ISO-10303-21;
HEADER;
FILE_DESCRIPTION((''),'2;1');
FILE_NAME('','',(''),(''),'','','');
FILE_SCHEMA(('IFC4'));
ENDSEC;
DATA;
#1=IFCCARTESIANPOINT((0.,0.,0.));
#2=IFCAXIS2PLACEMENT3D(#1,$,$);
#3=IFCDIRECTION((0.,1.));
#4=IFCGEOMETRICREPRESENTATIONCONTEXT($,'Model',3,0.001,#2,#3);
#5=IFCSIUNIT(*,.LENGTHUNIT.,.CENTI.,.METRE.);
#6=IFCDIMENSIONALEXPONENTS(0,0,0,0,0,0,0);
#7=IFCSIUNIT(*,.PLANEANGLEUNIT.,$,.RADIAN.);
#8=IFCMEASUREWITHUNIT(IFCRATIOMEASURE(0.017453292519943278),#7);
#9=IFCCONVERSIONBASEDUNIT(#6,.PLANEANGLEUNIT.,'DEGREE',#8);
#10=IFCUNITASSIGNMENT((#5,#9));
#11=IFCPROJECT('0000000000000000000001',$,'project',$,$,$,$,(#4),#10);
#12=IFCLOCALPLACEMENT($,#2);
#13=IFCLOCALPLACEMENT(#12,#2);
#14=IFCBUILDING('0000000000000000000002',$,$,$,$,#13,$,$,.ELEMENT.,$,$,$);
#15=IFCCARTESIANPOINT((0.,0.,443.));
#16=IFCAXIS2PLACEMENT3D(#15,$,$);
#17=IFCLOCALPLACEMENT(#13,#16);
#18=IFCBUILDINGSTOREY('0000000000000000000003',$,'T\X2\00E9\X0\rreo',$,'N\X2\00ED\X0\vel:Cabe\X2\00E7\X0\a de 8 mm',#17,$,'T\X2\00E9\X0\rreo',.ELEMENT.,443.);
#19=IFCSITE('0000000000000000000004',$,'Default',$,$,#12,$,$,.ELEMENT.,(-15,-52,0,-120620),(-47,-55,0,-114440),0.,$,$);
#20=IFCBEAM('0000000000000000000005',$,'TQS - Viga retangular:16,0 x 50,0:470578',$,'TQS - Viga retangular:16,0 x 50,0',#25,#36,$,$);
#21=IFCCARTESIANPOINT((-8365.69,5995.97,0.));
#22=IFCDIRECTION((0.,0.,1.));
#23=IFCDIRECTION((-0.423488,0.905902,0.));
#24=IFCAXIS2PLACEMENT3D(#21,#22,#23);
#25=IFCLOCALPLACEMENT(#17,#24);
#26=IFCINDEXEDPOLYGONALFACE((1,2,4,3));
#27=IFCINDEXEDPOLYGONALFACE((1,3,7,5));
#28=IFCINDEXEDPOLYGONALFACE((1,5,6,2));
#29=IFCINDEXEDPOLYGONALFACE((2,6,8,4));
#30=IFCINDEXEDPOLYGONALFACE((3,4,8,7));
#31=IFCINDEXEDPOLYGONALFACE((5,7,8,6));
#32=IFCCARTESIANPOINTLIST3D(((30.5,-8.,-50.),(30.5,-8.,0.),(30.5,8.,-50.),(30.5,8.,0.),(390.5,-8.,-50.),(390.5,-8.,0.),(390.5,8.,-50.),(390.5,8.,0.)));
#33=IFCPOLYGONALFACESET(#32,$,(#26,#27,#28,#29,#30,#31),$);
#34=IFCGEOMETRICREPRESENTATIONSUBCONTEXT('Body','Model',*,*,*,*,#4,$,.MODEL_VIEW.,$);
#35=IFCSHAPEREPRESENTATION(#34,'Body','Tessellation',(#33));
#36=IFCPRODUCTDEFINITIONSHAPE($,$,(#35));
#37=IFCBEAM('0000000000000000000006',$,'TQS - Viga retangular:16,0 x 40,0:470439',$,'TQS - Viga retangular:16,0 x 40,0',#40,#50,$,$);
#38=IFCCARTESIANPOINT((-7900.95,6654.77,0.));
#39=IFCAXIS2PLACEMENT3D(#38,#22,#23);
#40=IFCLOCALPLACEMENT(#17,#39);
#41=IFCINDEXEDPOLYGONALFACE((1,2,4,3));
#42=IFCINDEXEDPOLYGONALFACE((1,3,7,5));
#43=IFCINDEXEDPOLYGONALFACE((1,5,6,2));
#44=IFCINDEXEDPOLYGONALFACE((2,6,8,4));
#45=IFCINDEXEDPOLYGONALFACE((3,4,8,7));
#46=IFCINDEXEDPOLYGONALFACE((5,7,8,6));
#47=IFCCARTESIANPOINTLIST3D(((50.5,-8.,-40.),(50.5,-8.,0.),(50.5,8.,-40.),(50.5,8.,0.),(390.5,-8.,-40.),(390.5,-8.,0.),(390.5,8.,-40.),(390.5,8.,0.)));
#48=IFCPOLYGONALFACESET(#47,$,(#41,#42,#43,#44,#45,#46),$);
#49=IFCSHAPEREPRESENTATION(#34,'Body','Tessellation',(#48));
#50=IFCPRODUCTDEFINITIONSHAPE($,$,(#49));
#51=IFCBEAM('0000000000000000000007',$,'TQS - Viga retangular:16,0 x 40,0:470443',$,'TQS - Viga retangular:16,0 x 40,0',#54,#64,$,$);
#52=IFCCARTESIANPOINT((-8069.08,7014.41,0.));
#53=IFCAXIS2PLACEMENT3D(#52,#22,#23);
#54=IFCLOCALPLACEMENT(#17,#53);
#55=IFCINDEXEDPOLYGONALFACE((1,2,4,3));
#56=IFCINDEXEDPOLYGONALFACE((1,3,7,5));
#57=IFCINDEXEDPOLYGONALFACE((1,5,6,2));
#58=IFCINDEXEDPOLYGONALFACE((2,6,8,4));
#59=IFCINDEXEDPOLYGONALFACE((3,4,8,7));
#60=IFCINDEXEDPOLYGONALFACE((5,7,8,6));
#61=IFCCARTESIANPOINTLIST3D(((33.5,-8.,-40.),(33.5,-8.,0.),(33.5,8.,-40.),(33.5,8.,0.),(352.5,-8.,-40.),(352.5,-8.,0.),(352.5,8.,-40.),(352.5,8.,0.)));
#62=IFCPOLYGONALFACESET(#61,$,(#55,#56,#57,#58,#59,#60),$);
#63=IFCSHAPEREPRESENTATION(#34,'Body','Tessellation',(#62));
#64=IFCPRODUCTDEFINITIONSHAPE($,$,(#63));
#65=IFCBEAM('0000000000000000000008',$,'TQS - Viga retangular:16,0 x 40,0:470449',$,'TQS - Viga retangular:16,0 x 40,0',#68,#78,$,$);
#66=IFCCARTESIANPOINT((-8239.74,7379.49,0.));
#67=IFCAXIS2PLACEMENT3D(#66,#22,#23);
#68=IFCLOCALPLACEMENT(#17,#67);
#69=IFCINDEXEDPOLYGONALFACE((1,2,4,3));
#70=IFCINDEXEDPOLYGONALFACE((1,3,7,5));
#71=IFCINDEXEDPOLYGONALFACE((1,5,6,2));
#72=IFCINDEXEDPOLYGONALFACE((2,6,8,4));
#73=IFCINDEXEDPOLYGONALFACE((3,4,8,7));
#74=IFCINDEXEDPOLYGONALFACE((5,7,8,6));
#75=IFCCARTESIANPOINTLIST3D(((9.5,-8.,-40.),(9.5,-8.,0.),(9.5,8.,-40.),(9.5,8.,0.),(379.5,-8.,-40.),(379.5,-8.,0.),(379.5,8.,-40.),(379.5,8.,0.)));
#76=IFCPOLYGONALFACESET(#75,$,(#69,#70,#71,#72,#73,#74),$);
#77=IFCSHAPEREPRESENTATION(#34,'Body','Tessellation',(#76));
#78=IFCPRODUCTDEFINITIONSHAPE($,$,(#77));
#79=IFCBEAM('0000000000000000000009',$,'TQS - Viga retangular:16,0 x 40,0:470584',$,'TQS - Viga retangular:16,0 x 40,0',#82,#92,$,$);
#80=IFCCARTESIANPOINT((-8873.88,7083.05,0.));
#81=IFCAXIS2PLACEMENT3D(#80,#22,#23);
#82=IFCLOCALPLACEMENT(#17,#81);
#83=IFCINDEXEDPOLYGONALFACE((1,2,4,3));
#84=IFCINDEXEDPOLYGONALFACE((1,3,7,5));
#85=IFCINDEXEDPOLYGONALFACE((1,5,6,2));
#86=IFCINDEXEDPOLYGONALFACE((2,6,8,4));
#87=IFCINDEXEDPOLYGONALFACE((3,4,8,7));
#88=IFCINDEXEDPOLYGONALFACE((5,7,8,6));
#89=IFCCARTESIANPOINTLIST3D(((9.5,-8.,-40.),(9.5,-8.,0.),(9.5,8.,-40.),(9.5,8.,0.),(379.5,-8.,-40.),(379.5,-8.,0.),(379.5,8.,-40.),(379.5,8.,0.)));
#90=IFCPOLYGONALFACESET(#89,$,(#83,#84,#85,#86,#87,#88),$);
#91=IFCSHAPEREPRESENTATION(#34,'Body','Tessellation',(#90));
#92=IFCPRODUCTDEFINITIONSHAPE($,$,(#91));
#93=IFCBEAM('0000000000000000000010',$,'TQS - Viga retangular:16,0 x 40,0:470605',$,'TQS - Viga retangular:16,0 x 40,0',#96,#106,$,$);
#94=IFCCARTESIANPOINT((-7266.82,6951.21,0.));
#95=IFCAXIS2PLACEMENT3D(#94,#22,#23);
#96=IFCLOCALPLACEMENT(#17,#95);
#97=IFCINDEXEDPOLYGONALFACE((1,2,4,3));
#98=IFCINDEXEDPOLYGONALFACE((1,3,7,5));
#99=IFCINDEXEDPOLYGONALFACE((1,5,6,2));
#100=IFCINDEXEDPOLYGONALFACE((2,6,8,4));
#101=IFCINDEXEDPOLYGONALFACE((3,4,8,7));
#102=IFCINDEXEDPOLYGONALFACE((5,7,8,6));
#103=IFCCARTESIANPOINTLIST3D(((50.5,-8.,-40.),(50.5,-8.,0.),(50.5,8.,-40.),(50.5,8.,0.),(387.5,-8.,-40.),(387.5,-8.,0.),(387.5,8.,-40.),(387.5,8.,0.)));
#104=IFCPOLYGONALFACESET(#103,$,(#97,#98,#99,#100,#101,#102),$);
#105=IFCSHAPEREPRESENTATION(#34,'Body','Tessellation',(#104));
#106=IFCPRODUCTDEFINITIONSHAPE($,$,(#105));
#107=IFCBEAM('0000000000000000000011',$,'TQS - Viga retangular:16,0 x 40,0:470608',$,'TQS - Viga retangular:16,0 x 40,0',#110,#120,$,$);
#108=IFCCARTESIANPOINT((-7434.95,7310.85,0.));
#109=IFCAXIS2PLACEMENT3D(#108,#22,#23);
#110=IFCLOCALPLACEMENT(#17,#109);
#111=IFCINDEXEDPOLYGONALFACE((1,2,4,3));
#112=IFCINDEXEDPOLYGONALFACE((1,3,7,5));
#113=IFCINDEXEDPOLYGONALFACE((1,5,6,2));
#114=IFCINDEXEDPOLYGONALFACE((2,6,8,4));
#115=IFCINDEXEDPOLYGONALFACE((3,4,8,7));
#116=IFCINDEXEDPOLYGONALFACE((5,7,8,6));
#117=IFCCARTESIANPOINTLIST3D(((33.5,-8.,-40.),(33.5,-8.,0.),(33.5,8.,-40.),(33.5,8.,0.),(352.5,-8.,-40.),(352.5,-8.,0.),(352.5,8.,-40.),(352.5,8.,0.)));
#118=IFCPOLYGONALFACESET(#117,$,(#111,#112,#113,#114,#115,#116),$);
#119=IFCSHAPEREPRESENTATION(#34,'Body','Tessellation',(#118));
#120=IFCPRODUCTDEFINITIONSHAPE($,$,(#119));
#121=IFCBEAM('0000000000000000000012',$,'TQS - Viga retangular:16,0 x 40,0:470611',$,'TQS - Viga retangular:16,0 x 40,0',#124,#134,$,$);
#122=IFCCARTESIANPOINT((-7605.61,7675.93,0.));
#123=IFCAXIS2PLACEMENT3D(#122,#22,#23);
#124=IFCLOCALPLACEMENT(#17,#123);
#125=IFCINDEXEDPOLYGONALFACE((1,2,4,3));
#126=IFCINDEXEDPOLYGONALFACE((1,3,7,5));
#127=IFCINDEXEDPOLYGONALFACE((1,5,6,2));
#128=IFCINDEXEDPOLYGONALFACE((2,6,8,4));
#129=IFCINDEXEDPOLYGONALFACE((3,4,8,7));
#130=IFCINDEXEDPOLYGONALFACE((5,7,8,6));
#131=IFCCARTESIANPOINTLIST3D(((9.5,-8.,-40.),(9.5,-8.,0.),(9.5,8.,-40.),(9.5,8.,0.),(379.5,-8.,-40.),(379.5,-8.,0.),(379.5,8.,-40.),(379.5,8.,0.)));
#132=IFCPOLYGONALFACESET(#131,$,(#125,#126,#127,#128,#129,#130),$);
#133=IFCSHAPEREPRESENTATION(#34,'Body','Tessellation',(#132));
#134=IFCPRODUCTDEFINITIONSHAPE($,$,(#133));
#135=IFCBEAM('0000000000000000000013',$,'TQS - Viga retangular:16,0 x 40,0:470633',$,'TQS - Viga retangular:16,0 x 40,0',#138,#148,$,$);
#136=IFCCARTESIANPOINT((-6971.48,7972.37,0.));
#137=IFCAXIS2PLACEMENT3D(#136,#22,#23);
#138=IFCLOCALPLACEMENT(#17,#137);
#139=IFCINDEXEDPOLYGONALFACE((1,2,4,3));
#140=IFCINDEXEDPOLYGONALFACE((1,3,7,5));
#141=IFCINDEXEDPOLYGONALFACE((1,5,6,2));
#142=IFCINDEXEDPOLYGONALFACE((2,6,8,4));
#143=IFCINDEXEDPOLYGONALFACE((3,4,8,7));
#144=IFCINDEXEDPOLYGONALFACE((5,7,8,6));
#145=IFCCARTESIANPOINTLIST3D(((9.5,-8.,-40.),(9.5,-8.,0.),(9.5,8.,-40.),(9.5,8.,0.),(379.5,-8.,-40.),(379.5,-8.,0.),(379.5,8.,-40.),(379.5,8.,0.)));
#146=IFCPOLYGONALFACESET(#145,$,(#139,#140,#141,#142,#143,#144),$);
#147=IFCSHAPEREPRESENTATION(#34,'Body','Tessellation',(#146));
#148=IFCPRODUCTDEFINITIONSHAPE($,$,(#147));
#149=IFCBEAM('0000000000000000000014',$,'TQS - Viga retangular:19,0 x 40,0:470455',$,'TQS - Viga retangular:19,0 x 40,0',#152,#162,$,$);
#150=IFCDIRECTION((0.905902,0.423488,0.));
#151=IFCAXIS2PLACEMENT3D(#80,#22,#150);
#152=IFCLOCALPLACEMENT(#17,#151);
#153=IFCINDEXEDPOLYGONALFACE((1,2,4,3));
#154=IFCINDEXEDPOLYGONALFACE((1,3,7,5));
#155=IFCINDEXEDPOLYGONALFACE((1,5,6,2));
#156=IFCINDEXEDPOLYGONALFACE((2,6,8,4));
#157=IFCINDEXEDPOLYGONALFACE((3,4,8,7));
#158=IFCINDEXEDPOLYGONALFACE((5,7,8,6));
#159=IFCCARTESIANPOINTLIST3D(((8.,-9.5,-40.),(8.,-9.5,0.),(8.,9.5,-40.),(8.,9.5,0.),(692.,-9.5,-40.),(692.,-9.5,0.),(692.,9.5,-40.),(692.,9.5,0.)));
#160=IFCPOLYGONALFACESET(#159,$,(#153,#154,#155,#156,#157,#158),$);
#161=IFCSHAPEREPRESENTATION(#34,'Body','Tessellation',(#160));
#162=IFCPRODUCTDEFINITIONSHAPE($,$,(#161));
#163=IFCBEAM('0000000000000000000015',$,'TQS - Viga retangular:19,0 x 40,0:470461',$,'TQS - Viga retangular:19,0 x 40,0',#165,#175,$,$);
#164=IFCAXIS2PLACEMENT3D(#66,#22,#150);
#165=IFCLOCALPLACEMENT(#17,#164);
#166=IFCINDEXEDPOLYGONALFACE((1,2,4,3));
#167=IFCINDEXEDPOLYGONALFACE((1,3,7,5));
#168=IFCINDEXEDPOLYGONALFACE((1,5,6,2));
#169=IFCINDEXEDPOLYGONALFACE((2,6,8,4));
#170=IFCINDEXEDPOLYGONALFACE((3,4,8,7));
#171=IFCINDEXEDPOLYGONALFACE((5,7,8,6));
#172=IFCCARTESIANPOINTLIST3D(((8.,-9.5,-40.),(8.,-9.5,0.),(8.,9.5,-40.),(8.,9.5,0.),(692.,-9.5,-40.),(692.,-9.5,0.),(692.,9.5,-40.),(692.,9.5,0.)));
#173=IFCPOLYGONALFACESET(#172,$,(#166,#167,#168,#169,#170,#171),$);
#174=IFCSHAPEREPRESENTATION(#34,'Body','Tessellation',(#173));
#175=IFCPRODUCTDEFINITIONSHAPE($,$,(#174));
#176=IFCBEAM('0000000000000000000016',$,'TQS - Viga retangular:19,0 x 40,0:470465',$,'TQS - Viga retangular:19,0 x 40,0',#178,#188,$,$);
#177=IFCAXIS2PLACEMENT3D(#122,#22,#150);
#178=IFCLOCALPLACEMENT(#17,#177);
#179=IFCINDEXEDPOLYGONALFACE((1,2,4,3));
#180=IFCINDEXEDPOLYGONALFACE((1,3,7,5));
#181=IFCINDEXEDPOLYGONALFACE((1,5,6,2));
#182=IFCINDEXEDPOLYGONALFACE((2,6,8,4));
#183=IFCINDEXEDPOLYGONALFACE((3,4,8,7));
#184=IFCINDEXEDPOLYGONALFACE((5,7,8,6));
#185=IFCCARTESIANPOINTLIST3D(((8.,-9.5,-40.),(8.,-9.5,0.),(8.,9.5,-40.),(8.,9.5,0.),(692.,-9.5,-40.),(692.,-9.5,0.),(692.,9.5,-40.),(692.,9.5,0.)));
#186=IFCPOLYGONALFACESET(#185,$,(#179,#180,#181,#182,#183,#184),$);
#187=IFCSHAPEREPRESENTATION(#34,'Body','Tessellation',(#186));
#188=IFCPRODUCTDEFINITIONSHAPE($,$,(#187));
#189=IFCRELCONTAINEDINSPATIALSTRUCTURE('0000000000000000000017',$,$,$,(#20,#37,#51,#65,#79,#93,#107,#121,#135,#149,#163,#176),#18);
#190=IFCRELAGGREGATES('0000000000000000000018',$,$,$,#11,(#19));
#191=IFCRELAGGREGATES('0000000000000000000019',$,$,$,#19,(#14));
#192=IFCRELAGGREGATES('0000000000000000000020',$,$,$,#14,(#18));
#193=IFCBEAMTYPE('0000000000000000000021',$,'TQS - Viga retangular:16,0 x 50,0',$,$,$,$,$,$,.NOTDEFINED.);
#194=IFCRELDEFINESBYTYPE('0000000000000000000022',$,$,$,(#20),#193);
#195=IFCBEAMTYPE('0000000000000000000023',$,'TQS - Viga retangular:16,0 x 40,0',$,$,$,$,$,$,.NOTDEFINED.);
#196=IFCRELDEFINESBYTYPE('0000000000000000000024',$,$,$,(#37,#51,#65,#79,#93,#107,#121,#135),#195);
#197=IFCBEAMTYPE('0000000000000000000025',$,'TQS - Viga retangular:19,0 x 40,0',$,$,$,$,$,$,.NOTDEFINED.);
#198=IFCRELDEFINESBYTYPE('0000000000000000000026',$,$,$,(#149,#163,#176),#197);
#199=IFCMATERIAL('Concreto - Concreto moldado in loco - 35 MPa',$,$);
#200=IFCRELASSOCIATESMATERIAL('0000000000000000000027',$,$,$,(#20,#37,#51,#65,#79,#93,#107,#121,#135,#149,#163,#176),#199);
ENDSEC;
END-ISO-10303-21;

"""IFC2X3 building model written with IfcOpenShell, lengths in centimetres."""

from ifc_helpers import new_model, entity, si_unit, converted_unit, direction, frame, frame_2d, origin, origin_2d_with_axis, place, context, subcontext, project, spatial, rectangle, extrude, material, type_object, element, save


model = new_model("IFC2X3")

# Units and contexts
model_context = context("Model", 3, precision=0.001, world=origin(), true_north=direction((0.0, 1.0)))
body_context = subcontext(model_context, "Body", "Model", "MODEL_VIEW")
ifc_project = project(units=[si_unit("LENGTHUNIT", "METRE", prefix="CENTI"), converted_unit("PLANEANGLEUNIT", "DEGREE", entity("IfcRatioMeasure", 0.017453292519943278), si_unit("PLANEANGLEUNIT", "RADIAN"), dimensions=[0, 0, 0, 0, 0, 0, 0])], contexts=[model_context])

# Site, building, storey
site_placement = place(None, origin())
site = spatial("IfcSite", under=ifc_project, at=site_placement, Name="Default", CompositionType="ELEMENT", RefLatitude=(-15, -52, 0, -120620), RefLongitude=(-47, -55, 0, -114440), RefElevation=0.0)
building_placement = place(site_placement, origin())
building = spatial("IfcBuilding", under=site, at=building_placement, CompositionType="ELEMENT")
storey_placement = place(building_placement, frame((0.0, 0.0, 443.0)))
storey = spatial("IfcBuildingStorey", under=building, at=storey_placement, Name="Térreo", ObjectType="Nível:Cabeça de 8 mm", LongName="Térreo", CompositionType="ELEMENT", Elevation=443.0)

# Beams
ifc_material_1 = material(Name="Concreto - Concreto moldado in loco - 35 MPa")
beam_type_1 = type_object("IfcBeamType", Name="TQS - Viga retangular:16,0 x 50,0", PredefinedType="NOTDEFINED")
beam_1_placement = place(storey_placement, frame((-8365.69, 5995.97, 0.0), z_axis=(0.0, 0.0, 1.0), x_axis=(-0.423488, 0.905902, 0.0)))
element("IfcBeam", 1, at=beam_1_placement, inside=storey, type_object=beam_type_1, material=ifc_material_1, Name="TQS - Viga retangular:16,0 x 50,0:470578", ObjectType="TQS - Viga retangular:16,0 x 50,0", context=body_context, shape_type="SweptSolid", body=[
    extrude(rectangle(XDim=50.0, YDim=16.0, at=origin_2d_with_axis()), frame((30.5, 0.0, -25.0), z_axis=(1.0, 0.0, 0.0), x_axis=(0.0, 0.0, -1.0)), (0.0, 0.0, 1.0), 360.0),
])
beam_type_2 = type_object("IfcBeamType", Name="TQS - Viga retangular:16,0 x 40,0", PredefinedType="NOTDEFINED")
beam_2_placement = place(storey_placement, frame((-7900.95, 6654.77, 0.0), z_axis=(0.0, 0.0, 1.0), x_axis=(-0.423488, 0.905902, 0.0)))
element("IfcBeam", 2, at=beam_2_placement, inside=storey, type_object=beam_type_2, material=ifc_material_1, Name="TQS - Viga retangular:16,0 x 40,0:470439", ObjectType="TQS - Viga retangular:16,0 x 40,0", context=body_context, shape_type="SweptSolid", body=[
    extrude(rectangle(XDim=40.0, YDim=16.0, at=frame_2d((0.0, 0.0), x_axis=(1.0, 0.0))), frame((50.5, 0.0, -20.0), z_axis=(1.0, 0.0, 0.0), x_axis=(0.0, 0.0, -1.0)), (0.0, 0.0, 1.0), 340.0),
])
beam_3_placement = place(storey_placement, frame((-8069.08, 7014.41, 0.0), z_axis=(0.0, 0.0, 1.0), x_axis=(-0.423488, 0.905902, 0.0)))
element("IfcBeam", 3, at=beam_3_placement, inside=storey, type_object=beam_type_2, material=ifc_material_1, Name="TQS - Viga retangular:16,0 x 40,0:470443", ObjectType="TQS - Viga retangular:16,0 x 40,0", context=body_context, shape_type="SweptSolid", body=[
    extrude(rectangle(XDim=40.0, YDim=16.0, at=origin_2d_with_axis()), frame((33.5, 0.0, -20.0), z_axis=(1.0, 0.0, 0.0), x_axis=(0.0, 0.0, -1.0)), (0.0, 0.0, 1.0), 319.0),
])
beam_4_placement = place(storey_placement, frame((-8239.74, 7379.49, 0.0), z_axis=(0.0, 0.0, 1.0), x_axis=(-0.423488, 0.905902, 0.0)))
element("IfcBeam", 4, at=beam_4_placement, inside=storey, type_object=beam_type_2, material=ifc_material_1, Name="TQS - Viga retangular:16,0 x 40,0:470449", ObjectType="TQS - Viga retangular:16,0 x 40,0", context=body_context, shape_type="SweptSolid", body=[
    extrude(rectangle(XDim=40.0, YDim=16.0, at=origin_2d_with_axis()), frame((9.5, 0.0, -20.0), z_axis=(1.0, 0.0, 0.0), x_axis=(0.0, 0.0, -1.0)), (0.0, 0.0, 1.0), 370.0),
])
beam_5_placement = place(storey_placement, frame((-8873.88, 7083.05, 0.0), z_axis=(0.0, 0.0, 1.0), x_axis=(-0.423488, 0.905902, 0.0)))
element("IfcBeam", 5, at=beam_5_placement, inside=storey, type_object=beam_type_2, material=ifc_material_1, Name="TQS - Viga retangular:16,0 x 40,0:470584", ObjectType="TQS - Viga retangular:16,0 x 40,0", context=body_context, shape_type="SweptSolid", body=[
    extrude(rectangle(XDim=40.0, YDim=16.0, at=origin_2d_with_axis()), frame((9.5, 0.0, -20.0), z_axis=(1.0, 0.0, 0.0), x_axis=(0.0, 0.0, -1.0)), (0.0, 0.0, 1.0), 370.0),
])
beam_6_placement = place(storey_placement, frame((-7266.82, 6951.21, 0.0), z_axis=(0.0, 0.0, 1.0), x_axis=(-0.423488, 0.905902, 0.0)))
element("IfcBeam", 6, at=beam_6_placement, inside=storey, type_object=beam_type_2, material=ifc_material_1, Name="TQS - Viga retangular:16,0 x 40,0:470605", ObjectType="TQS - Viga retangular:16,0 x 40,0", context=body_context, shape_type="SweptSolid", body=[
    extrude(rectangle(XDim=40.0, YDim=16.0, at=frame_2d((0.0, 0.0), x_axis=(1.0, 0.0))), frame((50.5, 0.0, -20.0), z_axis=(1.0, 0.0, 0.0), x_axis=(0.0, 0.0, -1.0)), (0.0, 0.0, 1.0), 337.0),
])
beam_7_placement = place(storey_placement, frame((-7434.95, 7310.85, 0.0), z_axis=(0.0, 0.0, 1.0), x_axis=(-0.423488, 0.905902, 0.0)))
element("IfcBeam", 7, at=beam_7_placement, inside=storey, type_object=beam_type_2, material=ifc_material_1, Name="TQS - Viga retangular:16,0 x 40,0:470608", ObjectType="TQS - Viga retangular:16,0 x 40,0", context=body_context, shape_type="SweptSolid", body=[
    extrude(rectangle(XDim=40.0, YDim=16.0, at=frame_2d((0.0, 0.0), x_axis=(1.0, 0.0))), frame((33.5, 0.0, -20.0), z_axis=(1.0, 0.0, 0.0), x_axis=(0.0, 0.0, -1.0)), (0.0, 0.0, 1.0), 319.0),
])
beam_8_placement = place(storey_placement, frame((-7605.61, 7675.93, 0.0), z_axis=(0.0, 0.0, 1.0), x_axis=(-0.423488, 0.905902, 0.0)))
element("IfcBeam", 8, at=beam_8_placement, inside=storey, type_object=beam_type_2, material=ifc_material_1, Name="TQS - Viga retangular:16,0 x 40,0:470611", ObjectType="TQS - Viga retangular:16,0 x 40,0", context=body_context, shape_type="SweptSolid", body=[
    extrude(rectangle(XDim=40.0, YDim=16.0, at=frame_2d((0.0, 0.0), x_axis=(1.0, 0.0))), frame((9.5, 0.0, -20.0), z_axis=(1.0, 0.0, 0.0), x_axis=(0.0, 0.0, -1.0)), (0.0, 0.0, 1.0), 370.0),
])
beam_9_placement = place(storey_placement, frame((-6971.48, 7972.37, 0.0), z_axis=(0.0, 0.0, 1.0), x_axis=(-0.423488, 0.905902, 0.0)))
element("IfcBeam", 9, at=beam_9_placement, inside=storey, type_object=beam_type_2, material=ifc_material_1, Name="TQS - Viga retangular:16,0 x 40,0:470633", ObjectType="TQS - Viga retangular:16,0 x 40,0", context=body_context, shape_type="SweptSolid", body=[
    extrude(rectangle(XDim=40.0, YDim=16.0, at=origin_2d_with_axis()), frame((9.5, 0.0, -20.0), z_axis=(1.0, 0.0, 0.0), x_axis=(0.0, 0.0, -1.0)), (0.0, 0.0, 1.0), 370.0),
])
beam_type_3 = type_object("IfcBeamType", Name="TQS - Viga retangular:19,0 x 40,0", PredefinedType="NOTDEFINED")
beam_10_placement = place(storey_placement, frame((-8873.88, 7083.05, 0.0), z_axis=(0.0, 0.0, 1.0), x_axis=(0.905902, 0.423488, 0.0)))
element("IfcBeam", 10, at=beam_10_placement, inside=storey, type_object=beam_type_3, material=ifc_material_1, Name="TQS - Viga retangular:19,0 x 40,0:470455", ObjectType="TQS - Viga retangular:19,0 x 40,0", context=body_context, shape_type="SweptSolid", body=[
    extrude(rectangle(XDim=40.0, YDim=19.0, at=frame_2d((0.0, 0.0), x_axis=(1.0, 0.0))), frame((8.0, 0.0, -20.0), z_axis=(1.0, 0.0, 0.0), x_axis=(0.0, 0.0, -1.0)), (0.0, 0.0, 1.0), 684.0),
])
beam_11_placement = place(storey_placement, frame((-8239.74, 7379.49, 0.0), z_axis=(0.0, 0.0, 1.0), x_axis=(0.905902, 0.423488, 0.0)))
element("IfcBeam", 11, at=beam_11_placement, inside=storey, type_object=beam_type_3, material=ifc_material_1, Name="TQS - Viga retangular:19,0 x 40,0:470461", ObjectType="TQS - Viga retangular:19,0 x 40,0", context=body_context, shape_type="SweptSolid", body=[
    extrude(rectangle(XDim=40.0, YDim=19.0, at=frame_2d((0.0, 0.0), x_axis=(1.0, 0.0))), frame((8.0, 0.0, -20.0), z_axis=(1.0, 0.0, 0.0), x_axis=(0.0, 0.0, -1.0)), (0.0, 0.0, 1.0), 684.0),
])
beam_12_placement = place(storey_placement, frame((-7605.61, 7675.93, 0.0), z_axis=(0.0, 0.0, 1.0), x_axis=(0.905902, 0.423488, 0.0)))
element("IfcBeam", 12, at=beam_12_placement, inside=storey, type_object=beam_type_3, material=ifc_material_1, Name="TQS - Viga retangular:19,0 x 40,0:470465", ObjectType="TQS - Viga retangular:19,0 x 40,0", context=body_context, shape_type="SweptSolid", body=[
    extrude(rectangle(XDim=40.0, YDim=19.0, at=frame_2d((0.0, 0.0), x_axis=(1.0, 0.0))), frame((8.0, 0.0, -20.0), z_axis=(1.0, 0.0, 0.0), x_axis=(0.0, 0.0, -1.0)), (0.0, 0.0, 1.0), 684.0),
])

save(model, "model.ifc")
